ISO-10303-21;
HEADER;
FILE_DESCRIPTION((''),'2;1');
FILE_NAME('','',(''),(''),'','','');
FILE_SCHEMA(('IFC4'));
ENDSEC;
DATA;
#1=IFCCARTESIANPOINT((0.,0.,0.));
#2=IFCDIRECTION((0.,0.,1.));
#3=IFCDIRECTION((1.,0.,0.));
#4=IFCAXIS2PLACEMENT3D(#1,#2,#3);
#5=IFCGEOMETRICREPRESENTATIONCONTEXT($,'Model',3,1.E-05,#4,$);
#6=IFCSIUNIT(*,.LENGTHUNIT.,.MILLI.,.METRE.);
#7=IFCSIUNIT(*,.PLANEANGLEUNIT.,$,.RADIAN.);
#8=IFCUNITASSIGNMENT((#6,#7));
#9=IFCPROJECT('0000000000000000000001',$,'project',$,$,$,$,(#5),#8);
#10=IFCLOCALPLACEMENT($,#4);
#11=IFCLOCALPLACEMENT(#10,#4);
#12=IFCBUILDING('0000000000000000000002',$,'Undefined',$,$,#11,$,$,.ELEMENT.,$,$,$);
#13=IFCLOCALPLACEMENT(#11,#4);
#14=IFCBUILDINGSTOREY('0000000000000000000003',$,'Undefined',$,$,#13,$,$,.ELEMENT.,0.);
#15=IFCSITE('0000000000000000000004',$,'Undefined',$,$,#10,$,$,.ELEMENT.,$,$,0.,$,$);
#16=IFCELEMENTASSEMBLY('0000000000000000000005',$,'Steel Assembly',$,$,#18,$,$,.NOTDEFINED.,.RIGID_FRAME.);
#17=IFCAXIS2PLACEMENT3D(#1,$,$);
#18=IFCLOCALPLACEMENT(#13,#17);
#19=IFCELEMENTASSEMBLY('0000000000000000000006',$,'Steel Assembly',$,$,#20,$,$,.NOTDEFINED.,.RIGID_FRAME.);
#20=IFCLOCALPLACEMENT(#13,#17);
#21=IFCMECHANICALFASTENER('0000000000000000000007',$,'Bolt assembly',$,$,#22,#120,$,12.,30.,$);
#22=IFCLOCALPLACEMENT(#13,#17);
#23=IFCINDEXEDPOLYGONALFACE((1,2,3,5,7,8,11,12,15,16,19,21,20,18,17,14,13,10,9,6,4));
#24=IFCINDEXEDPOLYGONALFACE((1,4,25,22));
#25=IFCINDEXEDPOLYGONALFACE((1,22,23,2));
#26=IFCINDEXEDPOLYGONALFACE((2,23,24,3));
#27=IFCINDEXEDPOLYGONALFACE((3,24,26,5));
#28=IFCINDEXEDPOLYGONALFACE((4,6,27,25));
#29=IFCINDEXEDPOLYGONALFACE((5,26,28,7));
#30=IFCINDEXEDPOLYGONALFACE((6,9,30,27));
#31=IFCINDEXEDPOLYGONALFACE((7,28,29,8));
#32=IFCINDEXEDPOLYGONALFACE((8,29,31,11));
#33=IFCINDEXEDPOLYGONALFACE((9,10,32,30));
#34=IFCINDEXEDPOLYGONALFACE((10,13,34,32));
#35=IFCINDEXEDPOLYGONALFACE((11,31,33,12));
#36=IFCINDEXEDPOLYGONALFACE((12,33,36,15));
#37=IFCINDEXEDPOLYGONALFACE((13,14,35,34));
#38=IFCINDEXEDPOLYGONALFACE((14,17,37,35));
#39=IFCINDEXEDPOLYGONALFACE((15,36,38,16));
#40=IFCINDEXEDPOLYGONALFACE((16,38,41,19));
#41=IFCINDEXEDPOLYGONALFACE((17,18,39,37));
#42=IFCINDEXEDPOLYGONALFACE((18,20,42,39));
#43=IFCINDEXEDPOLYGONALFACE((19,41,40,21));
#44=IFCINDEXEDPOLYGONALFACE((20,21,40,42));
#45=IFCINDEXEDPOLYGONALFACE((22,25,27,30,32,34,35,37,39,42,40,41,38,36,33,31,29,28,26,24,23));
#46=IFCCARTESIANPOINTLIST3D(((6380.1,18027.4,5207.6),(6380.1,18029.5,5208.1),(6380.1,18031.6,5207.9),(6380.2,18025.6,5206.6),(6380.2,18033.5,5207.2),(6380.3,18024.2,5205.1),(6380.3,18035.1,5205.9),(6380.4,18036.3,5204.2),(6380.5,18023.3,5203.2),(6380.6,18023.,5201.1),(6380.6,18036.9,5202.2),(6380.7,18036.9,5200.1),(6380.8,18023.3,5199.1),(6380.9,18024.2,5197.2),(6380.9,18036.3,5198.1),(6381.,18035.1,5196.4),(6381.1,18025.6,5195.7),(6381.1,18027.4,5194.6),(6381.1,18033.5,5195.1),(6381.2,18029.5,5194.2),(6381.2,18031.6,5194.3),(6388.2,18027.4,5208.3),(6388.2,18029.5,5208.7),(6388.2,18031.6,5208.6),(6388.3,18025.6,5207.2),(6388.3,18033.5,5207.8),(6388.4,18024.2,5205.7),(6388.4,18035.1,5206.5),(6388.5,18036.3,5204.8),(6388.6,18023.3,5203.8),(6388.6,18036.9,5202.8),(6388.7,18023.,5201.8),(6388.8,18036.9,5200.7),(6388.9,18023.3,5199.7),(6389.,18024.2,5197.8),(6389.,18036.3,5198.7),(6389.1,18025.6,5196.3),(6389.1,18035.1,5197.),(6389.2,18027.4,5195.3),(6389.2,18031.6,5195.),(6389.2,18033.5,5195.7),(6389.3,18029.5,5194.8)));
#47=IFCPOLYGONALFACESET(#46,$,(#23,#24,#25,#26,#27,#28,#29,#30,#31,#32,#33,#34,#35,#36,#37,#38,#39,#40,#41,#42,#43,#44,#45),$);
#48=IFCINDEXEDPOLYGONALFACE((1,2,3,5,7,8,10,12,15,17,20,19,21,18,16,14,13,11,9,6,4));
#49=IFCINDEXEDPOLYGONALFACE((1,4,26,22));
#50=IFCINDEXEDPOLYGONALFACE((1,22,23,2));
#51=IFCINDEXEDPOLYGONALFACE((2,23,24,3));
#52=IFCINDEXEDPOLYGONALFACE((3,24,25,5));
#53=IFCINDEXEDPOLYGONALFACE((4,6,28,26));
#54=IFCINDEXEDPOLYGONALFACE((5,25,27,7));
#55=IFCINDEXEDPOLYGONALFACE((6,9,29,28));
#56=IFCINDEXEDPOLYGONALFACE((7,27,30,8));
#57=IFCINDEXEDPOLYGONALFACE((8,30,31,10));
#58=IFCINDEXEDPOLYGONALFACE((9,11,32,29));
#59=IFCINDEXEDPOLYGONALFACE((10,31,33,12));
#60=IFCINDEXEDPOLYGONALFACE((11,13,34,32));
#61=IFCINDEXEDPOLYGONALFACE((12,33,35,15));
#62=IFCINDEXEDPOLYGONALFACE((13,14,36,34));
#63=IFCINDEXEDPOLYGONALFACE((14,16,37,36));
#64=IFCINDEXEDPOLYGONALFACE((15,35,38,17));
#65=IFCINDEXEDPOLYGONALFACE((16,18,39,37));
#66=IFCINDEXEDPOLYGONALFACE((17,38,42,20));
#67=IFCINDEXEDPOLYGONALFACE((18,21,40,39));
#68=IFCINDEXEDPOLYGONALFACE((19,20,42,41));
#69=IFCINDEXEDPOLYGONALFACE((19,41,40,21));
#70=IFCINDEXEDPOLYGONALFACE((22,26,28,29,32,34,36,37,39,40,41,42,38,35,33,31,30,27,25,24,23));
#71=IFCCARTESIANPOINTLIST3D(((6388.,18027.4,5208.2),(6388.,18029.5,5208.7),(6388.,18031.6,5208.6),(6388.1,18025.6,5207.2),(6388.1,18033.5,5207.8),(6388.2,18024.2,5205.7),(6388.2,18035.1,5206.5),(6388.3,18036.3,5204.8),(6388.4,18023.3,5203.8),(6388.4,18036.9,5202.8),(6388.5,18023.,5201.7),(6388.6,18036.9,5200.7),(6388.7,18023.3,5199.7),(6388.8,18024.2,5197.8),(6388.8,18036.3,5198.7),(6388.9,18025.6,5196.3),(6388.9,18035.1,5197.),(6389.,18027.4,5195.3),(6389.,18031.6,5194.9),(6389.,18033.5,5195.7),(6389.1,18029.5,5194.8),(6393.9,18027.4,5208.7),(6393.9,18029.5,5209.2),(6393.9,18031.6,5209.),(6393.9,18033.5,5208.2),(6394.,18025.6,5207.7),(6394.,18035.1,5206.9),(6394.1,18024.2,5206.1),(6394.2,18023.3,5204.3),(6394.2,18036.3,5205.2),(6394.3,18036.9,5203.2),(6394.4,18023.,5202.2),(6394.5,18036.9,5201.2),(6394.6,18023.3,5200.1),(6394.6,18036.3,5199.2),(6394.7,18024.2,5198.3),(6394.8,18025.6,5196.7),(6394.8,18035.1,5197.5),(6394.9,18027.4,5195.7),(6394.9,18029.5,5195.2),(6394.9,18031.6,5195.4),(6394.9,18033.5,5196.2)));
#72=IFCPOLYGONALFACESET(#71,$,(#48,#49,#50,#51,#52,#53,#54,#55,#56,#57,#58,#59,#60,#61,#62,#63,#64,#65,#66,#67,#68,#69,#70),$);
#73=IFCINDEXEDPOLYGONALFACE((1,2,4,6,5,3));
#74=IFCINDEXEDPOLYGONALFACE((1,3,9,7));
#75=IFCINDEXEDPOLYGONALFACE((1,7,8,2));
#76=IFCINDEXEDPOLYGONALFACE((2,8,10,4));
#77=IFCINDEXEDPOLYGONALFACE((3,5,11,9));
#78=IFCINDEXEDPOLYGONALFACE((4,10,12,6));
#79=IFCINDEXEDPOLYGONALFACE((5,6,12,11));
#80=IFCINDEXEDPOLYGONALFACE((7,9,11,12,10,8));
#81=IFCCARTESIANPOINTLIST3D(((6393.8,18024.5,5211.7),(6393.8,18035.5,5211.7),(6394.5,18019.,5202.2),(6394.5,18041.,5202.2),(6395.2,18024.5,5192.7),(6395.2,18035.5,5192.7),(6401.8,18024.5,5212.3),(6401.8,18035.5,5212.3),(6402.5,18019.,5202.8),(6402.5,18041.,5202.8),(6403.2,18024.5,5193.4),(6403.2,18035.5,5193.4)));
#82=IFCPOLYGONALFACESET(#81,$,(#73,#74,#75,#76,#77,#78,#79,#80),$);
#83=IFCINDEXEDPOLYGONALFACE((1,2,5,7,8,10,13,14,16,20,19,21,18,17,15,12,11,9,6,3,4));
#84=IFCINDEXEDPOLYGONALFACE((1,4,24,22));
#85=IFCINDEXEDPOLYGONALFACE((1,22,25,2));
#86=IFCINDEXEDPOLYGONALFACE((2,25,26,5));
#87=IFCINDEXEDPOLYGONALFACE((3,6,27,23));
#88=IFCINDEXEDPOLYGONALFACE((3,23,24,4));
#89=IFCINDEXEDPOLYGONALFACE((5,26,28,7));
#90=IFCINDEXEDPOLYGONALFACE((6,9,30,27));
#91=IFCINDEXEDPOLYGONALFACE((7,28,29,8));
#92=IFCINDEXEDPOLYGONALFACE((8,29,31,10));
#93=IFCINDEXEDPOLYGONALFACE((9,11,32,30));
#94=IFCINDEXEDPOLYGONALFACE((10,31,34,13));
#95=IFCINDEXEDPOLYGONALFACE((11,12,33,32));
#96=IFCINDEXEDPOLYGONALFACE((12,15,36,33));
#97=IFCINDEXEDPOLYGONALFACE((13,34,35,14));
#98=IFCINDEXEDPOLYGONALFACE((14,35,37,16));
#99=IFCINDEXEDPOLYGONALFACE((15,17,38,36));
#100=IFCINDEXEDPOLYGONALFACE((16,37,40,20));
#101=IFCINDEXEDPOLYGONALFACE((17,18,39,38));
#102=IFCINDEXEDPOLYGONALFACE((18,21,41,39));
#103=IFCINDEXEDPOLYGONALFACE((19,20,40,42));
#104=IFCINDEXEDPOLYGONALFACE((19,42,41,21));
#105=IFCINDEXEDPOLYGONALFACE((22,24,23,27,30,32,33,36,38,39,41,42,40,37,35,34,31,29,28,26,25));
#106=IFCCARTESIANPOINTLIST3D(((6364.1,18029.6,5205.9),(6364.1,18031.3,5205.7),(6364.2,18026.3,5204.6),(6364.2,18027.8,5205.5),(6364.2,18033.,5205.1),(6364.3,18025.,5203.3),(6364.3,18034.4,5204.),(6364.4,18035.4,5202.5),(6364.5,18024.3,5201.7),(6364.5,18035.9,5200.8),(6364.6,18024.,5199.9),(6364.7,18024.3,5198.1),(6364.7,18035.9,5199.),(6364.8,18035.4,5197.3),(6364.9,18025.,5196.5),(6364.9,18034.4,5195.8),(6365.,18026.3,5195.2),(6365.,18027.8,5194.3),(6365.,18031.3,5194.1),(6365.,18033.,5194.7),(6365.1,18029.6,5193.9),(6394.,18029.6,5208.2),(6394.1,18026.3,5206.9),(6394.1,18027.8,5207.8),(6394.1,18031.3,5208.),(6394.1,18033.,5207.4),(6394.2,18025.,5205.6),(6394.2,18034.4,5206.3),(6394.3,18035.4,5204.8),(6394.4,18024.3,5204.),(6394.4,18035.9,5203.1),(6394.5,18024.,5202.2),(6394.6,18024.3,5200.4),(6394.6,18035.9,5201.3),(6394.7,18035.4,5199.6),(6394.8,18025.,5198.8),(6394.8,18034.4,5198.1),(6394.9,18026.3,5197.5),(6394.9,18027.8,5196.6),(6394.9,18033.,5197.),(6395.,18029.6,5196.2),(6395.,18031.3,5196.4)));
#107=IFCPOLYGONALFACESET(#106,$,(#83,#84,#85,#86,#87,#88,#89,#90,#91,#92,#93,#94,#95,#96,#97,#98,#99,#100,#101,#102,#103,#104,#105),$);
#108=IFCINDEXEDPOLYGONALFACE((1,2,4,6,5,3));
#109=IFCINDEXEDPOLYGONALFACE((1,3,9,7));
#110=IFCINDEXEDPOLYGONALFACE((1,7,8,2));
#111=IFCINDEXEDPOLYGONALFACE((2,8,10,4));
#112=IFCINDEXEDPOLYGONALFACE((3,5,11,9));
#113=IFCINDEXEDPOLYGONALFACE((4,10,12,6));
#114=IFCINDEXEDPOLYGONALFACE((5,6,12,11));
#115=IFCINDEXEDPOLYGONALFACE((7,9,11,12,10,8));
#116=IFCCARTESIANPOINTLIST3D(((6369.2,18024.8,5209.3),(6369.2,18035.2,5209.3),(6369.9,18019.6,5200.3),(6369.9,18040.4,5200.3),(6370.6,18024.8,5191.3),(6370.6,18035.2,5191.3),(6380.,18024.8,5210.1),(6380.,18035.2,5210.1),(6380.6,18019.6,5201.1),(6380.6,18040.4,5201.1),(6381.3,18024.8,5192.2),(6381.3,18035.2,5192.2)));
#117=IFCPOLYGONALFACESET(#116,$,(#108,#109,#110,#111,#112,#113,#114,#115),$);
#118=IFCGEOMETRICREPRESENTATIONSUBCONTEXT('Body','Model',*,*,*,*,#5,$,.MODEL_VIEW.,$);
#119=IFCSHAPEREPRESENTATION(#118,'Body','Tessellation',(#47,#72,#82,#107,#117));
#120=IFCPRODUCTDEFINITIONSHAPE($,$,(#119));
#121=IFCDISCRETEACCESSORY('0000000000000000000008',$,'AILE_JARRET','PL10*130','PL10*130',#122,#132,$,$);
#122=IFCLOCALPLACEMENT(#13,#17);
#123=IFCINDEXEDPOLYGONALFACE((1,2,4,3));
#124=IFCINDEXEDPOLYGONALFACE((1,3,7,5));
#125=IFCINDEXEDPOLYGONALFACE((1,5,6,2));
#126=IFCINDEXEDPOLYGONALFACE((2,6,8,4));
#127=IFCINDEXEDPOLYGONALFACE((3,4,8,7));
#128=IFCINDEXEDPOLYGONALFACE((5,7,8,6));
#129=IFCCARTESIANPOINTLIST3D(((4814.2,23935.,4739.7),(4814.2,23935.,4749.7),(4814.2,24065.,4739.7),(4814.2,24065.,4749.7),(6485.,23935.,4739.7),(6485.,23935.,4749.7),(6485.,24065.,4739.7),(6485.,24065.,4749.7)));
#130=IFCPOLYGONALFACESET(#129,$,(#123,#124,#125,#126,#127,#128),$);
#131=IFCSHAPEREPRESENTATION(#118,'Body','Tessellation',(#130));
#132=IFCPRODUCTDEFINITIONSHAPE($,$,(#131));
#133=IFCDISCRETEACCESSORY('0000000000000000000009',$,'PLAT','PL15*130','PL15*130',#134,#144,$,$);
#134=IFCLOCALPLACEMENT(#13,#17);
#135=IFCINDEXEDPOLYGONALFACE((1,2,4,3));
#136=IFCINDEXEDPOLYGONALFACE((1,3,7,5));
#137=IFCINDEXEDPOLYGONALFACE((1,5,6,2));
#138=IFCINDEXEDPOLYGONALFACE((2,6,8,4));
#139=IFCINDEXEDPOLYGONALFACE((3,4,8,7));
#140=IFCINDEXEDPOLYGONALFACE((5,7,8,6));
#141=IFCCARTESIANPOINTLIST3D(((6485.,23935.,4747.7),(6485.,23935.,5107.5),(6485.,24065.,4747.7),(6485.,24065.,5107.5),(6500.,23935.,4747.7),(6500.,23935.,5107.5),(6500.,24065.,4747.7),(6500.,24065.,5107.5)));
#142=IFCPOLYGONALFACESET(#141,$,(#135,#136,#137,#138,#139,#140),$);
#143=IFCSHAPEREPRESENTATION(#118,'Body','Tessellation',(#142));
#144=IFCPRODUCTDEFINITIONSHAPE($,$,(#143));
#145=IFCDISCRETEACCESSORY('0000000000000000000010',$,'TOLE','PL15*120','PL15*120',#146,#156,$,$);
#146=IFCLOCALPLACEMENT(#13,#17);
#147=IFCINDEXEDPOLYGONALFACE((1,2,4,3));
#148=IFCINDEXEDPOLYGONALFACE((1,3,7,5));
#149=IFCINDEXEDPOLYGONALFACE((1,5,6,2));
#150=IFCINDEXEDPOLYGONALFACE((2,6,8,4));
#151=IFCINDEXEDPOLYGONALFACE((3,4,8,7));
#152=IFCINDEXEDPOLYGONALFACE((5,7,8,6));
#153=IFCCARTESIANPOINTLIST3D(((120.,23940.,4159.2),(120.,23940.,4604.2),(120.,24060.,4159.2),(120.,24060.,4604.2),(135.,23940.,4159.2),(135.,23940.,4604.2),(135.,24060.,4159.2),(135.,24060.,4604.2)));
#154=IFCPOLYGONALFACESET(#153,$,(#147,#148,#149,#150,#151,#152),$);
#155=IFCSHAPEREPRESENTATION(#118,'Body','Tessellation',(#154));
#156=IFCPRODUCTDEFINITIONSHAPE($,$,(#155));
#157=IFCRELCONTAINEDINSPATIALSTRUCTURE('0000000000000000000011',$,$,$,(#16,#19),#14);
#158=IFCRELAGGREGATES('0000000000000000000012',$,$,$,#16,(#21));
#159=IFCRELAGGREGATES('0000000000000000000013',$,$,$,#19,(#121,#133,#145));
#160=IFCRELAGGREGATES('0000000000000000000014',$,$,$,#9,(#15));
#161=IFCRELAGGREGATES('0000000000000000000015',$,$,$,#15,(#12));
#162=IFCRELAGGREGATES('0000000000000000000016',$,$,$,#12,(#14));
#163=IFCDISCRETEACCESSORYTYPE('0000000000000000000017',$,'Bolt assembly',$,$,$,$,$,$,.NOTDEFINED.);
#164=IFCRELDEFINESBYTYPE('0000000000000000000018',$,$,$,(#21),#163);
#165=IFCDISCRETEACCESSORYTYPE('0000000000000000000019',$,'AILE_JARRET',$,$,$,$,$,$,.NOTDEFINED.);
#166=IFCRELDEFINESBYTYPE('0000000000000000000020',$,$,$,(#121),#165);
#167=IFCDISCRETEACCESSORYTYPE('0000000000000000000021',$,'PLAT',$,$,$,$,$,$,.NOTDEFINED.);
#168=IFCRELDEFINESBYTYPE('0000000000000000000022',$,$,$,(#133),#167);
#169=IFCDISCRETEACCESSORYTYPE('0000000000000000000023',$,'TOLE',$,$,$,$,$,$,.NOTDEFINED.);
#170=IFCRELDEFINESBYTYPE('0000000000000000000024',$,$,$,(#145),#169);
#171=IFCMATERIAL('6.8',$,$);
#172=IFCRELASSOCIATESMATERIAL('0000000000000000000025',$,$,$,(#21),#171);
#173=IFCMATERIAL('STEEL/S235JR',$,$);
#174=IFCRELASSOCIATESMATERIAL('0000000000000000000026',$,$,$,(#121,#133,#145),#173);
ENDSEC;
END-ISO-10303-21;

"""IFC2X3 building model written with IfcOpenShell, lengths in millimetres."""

from ifc_helpers import new_model, si_unit, frame, origin_with_axes, origin_2d_with_axis, place, context, subcontext, project, spatial, polyline, circle, outline, extrude, source, transform, mapped, material, type_object, element, aggregate, save


model = new_model("IFC2X3")

# Units and contexts
model_context = context("Model", 3, precision=1e-05, world=origin_with_axes())
body_context = subcontext(model_context, "Body", "Model", "MODEL_VIEW")
ifc_project = project(units=[si_unit("LENGTHUNIT", "METRE", prefix="MILLI"), si_unit("PLANEANGLEUNIT", "RADIAN")], contexts=[model_context])

# Site, building, storey
site_placement = place(None, origin_with_axes())
site = spatial("IfcSite", under=ifc_project, at=site_placement, Name="Undefined", CompositionType="ELEMENT", RefElevation=0.0)
building_placement = place(site_placement, origin_with_axes())
building = spatial("IfcBuilding", under=site, at=building_placement, Name="Undefined", CompositionType="ELEMENT")
storey_placement = place(building_placement, origin_with_axes())
storey = spatial("IfcBuildingStorey", under=building, at=storey_placement, Name="Undefined", CompositionType="ELEMENT", Elevation=0.0)

# Element assemblies
ifc_material_1 = material(Name="STEEL/S235JR")
assembly_1_placement = place(storey_placement, origin_with_axes())
assembly_1 = element("IfcElementAssembly", 1, at=assembly_1_placement, inside=storey, Name="Steel Assembly", AssemblyPlace="NOTDEFINED", PredefinedType="RIGID_FRAME")
assembly_2_placement = place(storey_placement, origin_with_axes())
assembly_2 = element("IfcElementAssembly", 2, at=assembly_2_placement, inside=storey, Name="Steel Assembly", AssemblyPlace="NOTDEFINED", PredefinedType="RIGID_FRAME")

# Shared definitions
ifc_material_2 = material(Name="6.8")
discrete_accessory_type_1 = type_object("IfcDiscreteAccessoryType", Name="Bolt assembly")

# Mechanical fastener
shared_shape_1 = source(origin_with_axes(), body_context, "Body", "SweptSolid", [
    extrude(circle(Radius=7.0, at=origin_2d_with_axis()), frame((0.0, 2.9, 0.0), z_axis=(0.0, 1.0, 0.0), x_axis=(1.0, 0.0, 0.0)), (0.0, 0.0, 1.0), 8.1),
    extrude(circle(Radius=7.0, at=origin_2d_with_axis()), frame((0.0, -2.9, 0.0), z_axis=(0.0, 1.0, 0.0), x_axis=(1.0, 0.0, 0.0)), (0.0, 0.0, 1.0), 5.9),
    extrude(outline(polyline([(11.0, 0.0), (5.5, 9.5), (-5.5, 9.5), (-11.0, 0.0), (-5.5, -9.5), (5.5, -9.5), (11.0, 0.0)])), frame((0.0, -11.0, 0.0), z_axis=(0.0, 1.0, 0.0), x_axis=(1.0, 0.0, 0.0)), (0.0, 0.0, 1.0), 8.0),
    extrude(circle(Radius=6.0, at=origin_2d_with_axis()), frame((0.0, -3.0, 0.0), z_axis=(0.0, 1.0, 0.0), x_axis=(1.0, 0.0, 0.0)), (0.0, 0.0, 1.0), 30.0),
    extrude(outline(polyline([(10.4, 0.0), (5.2, 9.0), (-5.2, 9.0), (-10.4, 0.0), (-5.2, -9.0), (5.2, -9.0), (10.4, 0.0)])), frame((0.0, 11.0, 0.0), z_axis=(0.0, 1.0, 0.0), x_axis=(1.0, 0.0, 0.0)), (0.0, 0.0, 1.0), 10.8),
])
mechanical_fastener_1_placement = place(assembly_1_placement, frame((6391.6, 18000.0, 5202.0), z_axis=(0.076696, 0.0, -0.997054), x_axis=(0.0, -1.0, 0.0)))
mechanical_fastener_1 = element("IfcMechanicalFastener", 3, at=mechanical_fastener_1_placement, type_object=discrete_accessory_type_1, material=ifc_material_2, Name="Bolt assembly", NominalDiameter=12.0, NominalLength=30.0, context=body_context, shape_type="MappedRepresentation", body=[
    mapped(shared_shape_1, transform((-30.0, 0.0, 0.0))),
])
aggregate(assembly_1, [mechanical_fastener_1])

# Discrete accessories
discrete_accessory_type_2 = type_object("IfcDiscreteAccessoryType", Name="AILE_JARRET")
discrete_accessory_1_placement = place(assembly_2_placement, frame((4814.2, 24000.0, 4744.7), z_axis=(0.0, 0.0, -1.0), x_axis=(1.0, 0.0, 0.0)))
discrete_accessory_1 = element("IfcDiscreteAccessory", 4, at=discrete_accessory_1_placement, type_object=discrete_accessory_type_2, material=ifc_material_1, Name="AILE_JARRET", Description="PL10*130", ObjectType="PL10*130", context=body_context, shape_type="SweptSolid", body=[
    extrude(outline(polyline([(0.0, 65.0), (1670.8, 65.0), (1670.8, -65.0), (0.0, -65.0), (0.0, 65.0)])), frame((0.0, 0.0, -5.0), z_axis=(0.0, 0.0, 1.0), x_axis=(1.0, 0.0, 0.0)), (0.0, 0.0, 1.0), 10.0),
])
discrete_accessory_type_3 = type_object("IfcDiscreteAccessoryType", Name="PLAT")
discrete_accessory_2_placement = place(assembly_2_placement, frame((6492.5, 24000.0, 5107.5), z_axis=(-1.0, 0.0, 0.0), x_axis=(0.0, 0.0, -1.0)))
discrete_accessory_2 = element("IfcDiscreteAccessory", 5, at=discrete_accessory_2_placement, type_object=discrete_accessory_type_3, material=ifc_material_1, Name="PLAT", Description="PL15*130", ObjectType="PL15*130", context=body_context, shape_type="SweptSolid", body=[
    extrude(outline(polyline([(359.8, 65.0), (359.8, -65.0), (0.0, -65.0), (0.0, 65.0), (359.8, 65.0)])), frame((0.0, 0.0, -7.5), z_axis=(0.0, 0.0, 1.0), x_axis=(1.0, 0.0, 0.0)), (0.0, 0.0, 1.0), 15.0),
])

# Discrete accessory
discrete_accessory_type_4 = type_object("IfcDiscreteAccessoryType", Name="TOLE")
discrete_accessory_3_placement = place(assembly_2_placement, frame((127.5, 24000.0, 4159.2), z_axis=(1.0, 0.0, 0.0), x_axis=(0.0, 0.0, 1.0)))
discrete_accessory_3 = element("IfcDiscreteAccessory", 6, at=discrete_accessory_3_placement, type_object=discrete_accessory_type_4, material=ifc_material_1, Name="TOLE", Description="PL15*120", ObjectType="PL15*120", context=body_context, shape_type="SweptSolid", body=[
    extrude(outline(polyline([(0.0, 60.0), (445.0, 60.0), (445.0, -60.0), (0.0, -60.0), (0.0, 60.0)])), frame((0.0, 0.0, -7.5), z_axis=(0.0, 0.0, 1.0), x_axis=(1.0, 0.0, 0.0)), (0.0, 0.0, 1.0), 15.0),
])
aggregate(assembly_2, [discrete_accessory_1, discrete_accessory_2, discrete_accessory_3])

save(model, "model.ifc")
